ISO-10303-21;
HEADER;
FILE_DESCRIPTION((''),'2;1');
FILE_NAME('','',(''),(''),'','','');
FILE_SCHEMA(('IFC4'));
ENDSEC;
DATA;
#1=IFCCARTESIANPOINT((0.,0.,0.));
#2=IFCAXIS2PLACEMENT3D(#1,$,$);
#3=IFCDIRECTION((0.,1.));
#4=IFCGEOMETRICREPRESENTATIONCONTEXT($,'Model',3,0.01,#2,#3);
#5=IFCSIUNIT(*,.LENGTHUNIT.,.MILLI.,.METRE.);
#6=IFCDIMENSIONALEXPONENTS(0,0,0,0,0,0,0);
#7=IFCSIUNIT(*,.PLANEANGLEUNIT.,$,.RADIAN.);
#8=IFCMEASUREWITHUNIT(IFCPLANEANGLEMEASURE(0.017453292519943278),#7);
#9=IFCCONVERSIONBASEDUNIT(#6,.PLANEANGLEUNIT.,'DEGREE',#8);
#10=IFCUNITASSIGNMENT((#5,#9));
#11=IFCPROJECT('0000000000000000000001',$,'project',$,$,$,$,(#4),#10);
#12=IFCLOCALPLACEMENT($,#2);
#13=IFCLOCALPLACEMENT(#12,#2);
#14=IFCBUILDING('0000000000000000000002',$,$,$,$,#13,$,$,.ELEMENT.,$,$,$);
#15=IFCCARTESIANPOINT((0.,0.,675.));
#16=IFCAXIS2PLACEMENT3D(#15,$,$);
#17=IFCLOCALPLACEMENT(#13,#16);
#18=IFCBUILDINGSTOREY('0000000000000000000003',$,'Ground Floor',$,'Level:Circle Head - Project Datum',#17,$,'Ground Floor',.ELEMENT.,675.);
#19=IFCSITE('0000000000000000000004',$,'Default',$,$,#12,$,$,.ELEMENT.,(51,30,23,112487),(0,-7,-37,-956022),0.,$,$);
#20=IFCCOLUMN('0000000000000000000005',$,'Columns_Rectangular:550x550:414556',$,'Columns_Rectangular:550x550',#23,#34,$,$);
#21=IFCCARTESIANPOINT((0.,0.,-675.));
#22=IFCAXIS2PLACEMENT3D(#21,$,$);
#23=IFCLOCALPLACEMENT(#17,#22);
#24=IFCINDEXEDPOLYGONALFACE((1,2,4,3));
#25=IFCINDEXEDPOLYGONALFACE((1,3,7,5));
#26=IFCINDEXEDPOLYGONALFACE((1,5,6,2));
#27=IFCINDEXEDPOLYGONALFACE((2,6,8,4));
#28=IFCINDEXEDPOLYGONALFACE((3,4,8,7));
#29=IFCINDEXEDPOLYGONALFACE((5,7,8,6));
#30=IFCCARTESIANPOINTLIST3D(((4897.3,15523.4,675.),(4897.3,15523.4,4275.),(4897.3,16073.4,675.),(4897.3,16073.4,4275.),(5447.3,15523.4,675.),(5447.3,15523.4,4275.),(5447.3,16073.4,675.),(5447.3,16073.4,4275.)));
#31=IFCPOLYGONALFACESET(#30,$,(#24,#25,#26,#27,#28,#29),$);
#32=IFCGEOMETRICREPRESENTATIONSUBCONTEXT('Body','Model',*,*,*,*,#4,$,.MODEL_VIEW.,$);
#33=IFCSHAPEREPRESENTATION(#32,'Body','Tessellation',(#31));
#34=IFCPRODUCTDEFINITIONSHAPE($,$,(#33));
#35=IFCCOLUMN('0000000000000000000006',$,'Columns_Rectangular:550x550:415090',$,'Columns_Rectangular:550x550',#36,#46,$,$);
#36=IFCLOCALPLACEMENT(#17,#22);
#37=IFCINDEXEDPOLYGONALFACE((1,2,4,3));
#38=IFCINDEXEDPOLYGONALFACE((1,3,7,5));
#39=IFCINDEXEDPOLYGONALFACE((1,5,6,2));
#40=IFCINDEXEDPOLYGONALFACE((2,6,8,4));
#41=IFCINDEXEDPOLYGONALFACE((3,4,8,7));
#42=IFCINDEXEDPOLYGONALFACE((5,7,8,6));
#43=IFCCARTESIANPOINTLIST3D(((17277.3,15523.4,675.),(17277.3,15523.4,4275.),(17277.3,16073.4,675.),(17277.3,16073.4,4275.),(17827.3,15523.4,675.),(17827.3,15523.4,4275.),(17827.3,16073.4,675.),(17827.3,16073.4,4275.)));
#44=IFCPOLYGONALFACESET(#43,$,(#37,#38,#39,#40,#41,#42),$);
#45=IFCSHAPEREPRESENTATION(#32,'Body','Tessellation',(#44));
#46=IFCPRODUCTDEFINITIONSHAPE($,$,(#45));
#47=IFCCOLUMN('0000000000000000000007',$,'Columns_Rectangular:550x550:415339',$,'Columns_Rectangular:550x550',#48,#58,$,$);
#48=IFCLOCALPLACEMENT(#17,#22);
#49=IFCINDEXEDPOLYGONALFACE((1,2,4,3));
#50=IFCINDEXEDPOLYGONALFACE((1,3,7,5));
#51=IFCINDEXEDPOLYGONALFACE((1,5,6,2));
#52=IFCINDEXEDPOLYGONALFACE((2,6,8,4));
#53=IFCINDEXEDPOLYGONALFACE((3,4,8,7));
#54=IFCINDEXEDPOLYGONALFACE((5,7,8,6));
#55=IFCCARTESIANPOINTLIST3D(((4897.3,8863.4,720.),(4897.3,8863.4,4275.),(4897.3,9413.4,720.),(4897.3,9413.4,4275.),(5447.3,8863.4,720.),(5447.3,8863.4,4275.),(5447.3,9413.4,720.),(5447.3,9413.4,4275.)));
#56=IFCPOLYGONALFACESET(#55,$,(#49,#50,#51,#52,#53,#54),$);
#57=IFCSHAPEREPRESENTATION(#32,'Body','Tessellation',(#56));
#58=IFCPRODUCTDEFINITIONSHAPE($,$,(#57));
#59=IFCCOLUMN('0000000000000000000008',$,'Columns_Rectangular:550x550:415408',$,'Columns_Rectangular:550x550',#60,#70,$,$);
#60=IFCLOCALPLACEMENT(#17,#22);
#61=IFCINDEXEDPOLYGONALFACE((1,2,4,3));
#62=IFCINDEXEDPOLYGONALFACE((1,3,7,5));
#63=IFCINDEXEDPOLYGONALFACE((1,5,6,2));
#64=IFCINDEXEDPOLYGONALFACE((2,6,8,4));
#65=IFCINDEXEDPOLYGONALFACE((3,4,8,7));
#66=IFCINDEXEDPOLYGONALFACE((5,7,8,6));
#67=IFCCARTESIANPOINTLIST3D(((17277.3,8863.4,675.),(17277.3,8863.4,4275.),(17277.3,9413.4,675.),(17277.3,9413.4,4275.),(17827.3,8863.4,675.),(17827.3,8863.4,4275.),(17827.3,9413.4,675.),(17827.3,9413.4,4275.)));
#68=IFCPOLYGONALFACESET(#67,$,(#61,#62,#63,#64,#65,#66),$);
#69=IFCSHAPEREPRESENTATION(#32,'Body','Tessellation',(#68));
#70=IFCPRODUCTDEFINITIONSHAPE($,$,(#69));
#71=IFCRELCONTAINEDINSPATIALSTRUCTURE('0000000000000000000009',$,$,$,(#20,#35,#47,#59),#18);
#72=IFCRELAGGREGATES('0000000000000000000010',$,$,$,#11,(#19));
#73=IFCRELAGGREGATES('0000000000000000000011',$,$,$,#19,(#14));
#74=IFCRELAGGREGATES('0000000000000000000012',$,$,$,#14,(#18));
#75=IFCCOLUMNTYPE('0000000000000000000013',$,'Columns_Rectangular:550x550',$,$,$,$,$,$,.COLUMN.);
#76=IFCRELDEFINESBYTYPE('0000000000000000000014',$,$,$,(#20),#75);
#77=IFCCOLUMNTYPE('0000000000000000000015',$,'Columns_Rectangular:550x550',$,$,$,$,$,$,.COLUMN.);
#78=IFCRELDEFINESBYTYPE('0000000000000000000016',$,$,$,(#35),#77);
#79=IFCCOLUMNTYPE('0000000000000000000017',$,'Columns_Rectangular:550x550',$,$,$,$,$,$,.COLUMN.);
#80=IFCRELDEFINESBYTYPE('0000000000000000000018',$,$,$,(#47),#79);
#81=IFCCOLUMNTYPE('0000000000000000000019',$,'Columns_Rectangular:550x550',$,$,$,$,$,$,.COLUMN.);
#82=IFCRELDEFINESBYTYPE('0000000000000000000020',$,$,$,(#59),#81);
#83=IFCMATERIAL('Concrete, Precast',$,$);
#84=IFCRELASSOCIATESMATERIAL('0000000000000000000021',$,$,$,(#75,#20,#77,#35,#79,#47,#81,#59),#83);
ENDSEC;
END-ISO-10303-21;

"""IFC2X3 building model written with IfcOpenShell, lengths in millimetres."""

from ifc_helpers import new_model, entity, si_unit, converted_unit, direction, frame, frame_2d, origin, place, context, subcontext, project, spatial, rectangle, extrude, source, transform, mapped, material, type_object, type_shapes, element, save


model = new_model("IFC2X3")

# Units and contexts
model_context = context("Model", 3, precision=0.01, world=origin(), true_north=direction((0.0, 1.0)))
body_context = subcontext(model_context, "Body", "Model", "MODEL_VIEW")
ifc_project = project(units=[si_unit("LENGTHUNIT", "METRE", prefix="MILLI"), converted_unit("PLANEANGLEUNIT", "DEGREE", entity("IfcPlaneAngleMeasure", 0.017453292519943278), si_unit("PLANEANGLEUNIT", "RADIAN"), dimensions=[0, 0, 0, 0, 0, 0, 0])], contexts=[model_context])

# Site, building, storey
site_placement = place(None, origin())
site = spatial("IfcSite", under=ifc_project, at=site_placement, Name="Default", CompositionType="ELEMENT", RefLatitude=(51, 30, 23, 112487), RefLongitude=(0, -7, -37, -956022), RefElevation=0.0)
building_placement = place(site_placement, origin())
building = spatial("IfcBuilding", under=site, at=building_placement, CompositionType="ELEMENT")
storey_placement = place(building_placement, frame((0.0, 0.0, 675.0)))
storey = spatial("IfcBuildingStorey", under=building, at=storey_placement, Name="Ground Floor", ObjectType="Level:Circle Head - Project Datum", LongName="Ground Floor", CompositionType="ELEMENT", Elevation=675.0)

# Columns
ifc_material_1 = material(Name="Concrete, Precast")
column_type_1 = type_object("IfcColumnType", Name="Columns_Rectangular:550x550", PredefinedType="COLUMN", material=ifc_material_1)
shared_shape_1 = source(origin(), body_context, "Body", "SweptSolid", [
    extrude(rectangle(XDim=550.0, YDim=550.0, at=frame_2d((0.0, 0.0), x_axis=(1.0, 0.0))), frame((5172.3, 15798.4, 675.0), z_axis=(0.0, 0.0, 1.0), x_axis=(-1.0, 0.0, 0.0)), (0.0, 0.0, 1.0), 3600.0),
])
type_shapes(column_type_1, [shared_shape_1])
column_1_placement = place(storey_placement, frame((0.0, 0.0, -675.0)))
element("IfcColumn", 1, at=column_1_placement, inside=storey, type_object=column_type_1, material=ifc_material_1, Name="Columns_Rectangular:550x550:414556", ObjectType="Columns_Rectangular:550x550", context=body_context, shape_type="MappedRepresentation", body=[
    mapped(shared_shape_1, transform((0.0, 0.0, 0.0), scale=1.0)),
])
column_type_2 = type_object("IfcColumnType", Name="Columns_Rectangular:550x550", PredefinedType="COLUMN", material=ifc_material_1)
shared_shape_2 = source(origin(), body_context, "Body", "SweptSolid", [
    extrude(rectangle(XDim=550.0, YDim=550.0, at=frame_2d((0.0, 0.0), x_axis=(1.0, 0.0))), frame((17552.3, 15798.4, 675.0), z_axis=(0.0, 0.0, 1.0), x_axis=(-1.0, 0.0, 0.0)), (0.0, 0.0, 1.0), 3600.0),
])
type_shapes(column_type_2, [shared_shape_2])
column_2_placement = place(storey_placement, frame((0.0, 0.0, -675.0)))
element("IfcColumn", 2, at=column_2_placement, inside=storey, type_object=column_type_2, material=ifc_material_1, Name="Columns_Rectangular:550x550:415090", ObjectType="Columns_Rectangular:550x550", context=body_context, shape_type="MappedRepresentation", body=[
    mapped(shared_shape_2, transform((0.0, 0.0, 0.0), scale=1.0)),
])
column_type_3 = type_object("IfcColumnType", Name="Columns_Rectangular:550x550", PredefinedType="COLUMN", material=ifc_material_1)
shared_shape_3 = source(origin(), body_context, "Body", "SweptSolid", [
    extrude(rectangle(XDim=550.0, YDim=550.0, at=frame_2d((0.0, 0.0), x_axis=(1.0, 0.0))), frame((5172.3, 9138.4, 720.0), z_axis=(0.0, 0.0, 1.0), x_axis=(-1.0, 0.0, 0.0)), (0.0, 0.0, 1.0), 3555.0),
])
type_shapes(column_type_3, [shared_shape_3])
column_3_placement = place(storey_placement, frame((0.0, 0.0, -675.0)))
element("IfcColumn", 3, at=column_3_placement, inside=storey, type_object=column_type_3, material=ifc_material_1, Name="Columns_Rectangular:550x550:415339", ObjectType="Columns_Rectangular:550x550", context=body_context, shape_type="MappedRepresentation", body=[
    mapped(shared_shape_3, transform((0.0, 0.0, 0.0), scale=1.0)),
])
column_type_4 = type_object("IfcColumnType", Name="Columns_Rectangular:550x550", PredefinedType="COLUMN", material=ifc_material_1)
shared_shape_4 = source(origin(), body_context, "Body", "SweptSolid", [
    extrude(rectangle(XDim=550.0, YDim=550.0, at=frame_2d((0.0, 0.0), x_axis=(1.0, 0.0))), frame((17552.3, 9138.4, 675.0), z_axis=(0.0, 0.0, 1.0), x_axis=(-1.0, 0.0, 0.0)), (0.0, 0.0, 1.0), 3600.0),
])
type_shapes(column_type_4, [shared_shape_4])
column_4_placement = place(storey_placement, frame((0.0, 0.0, -675.0)))
element("IfcColumn", 4, at=column_4_placement, inside=storey, type_object=column_type_4, material=ifc_material_1, Name="Columns_Rectangular:550x550:415408", ObjectType="Columns_Rectangular:550x550", context=body_context, shape_type="MappedRepresentation", body=[
    mapped(shared_shape_4, transform((0.0, 0.0, 0.0), scale=1.0)),
])

save(model, "model.ifc")
